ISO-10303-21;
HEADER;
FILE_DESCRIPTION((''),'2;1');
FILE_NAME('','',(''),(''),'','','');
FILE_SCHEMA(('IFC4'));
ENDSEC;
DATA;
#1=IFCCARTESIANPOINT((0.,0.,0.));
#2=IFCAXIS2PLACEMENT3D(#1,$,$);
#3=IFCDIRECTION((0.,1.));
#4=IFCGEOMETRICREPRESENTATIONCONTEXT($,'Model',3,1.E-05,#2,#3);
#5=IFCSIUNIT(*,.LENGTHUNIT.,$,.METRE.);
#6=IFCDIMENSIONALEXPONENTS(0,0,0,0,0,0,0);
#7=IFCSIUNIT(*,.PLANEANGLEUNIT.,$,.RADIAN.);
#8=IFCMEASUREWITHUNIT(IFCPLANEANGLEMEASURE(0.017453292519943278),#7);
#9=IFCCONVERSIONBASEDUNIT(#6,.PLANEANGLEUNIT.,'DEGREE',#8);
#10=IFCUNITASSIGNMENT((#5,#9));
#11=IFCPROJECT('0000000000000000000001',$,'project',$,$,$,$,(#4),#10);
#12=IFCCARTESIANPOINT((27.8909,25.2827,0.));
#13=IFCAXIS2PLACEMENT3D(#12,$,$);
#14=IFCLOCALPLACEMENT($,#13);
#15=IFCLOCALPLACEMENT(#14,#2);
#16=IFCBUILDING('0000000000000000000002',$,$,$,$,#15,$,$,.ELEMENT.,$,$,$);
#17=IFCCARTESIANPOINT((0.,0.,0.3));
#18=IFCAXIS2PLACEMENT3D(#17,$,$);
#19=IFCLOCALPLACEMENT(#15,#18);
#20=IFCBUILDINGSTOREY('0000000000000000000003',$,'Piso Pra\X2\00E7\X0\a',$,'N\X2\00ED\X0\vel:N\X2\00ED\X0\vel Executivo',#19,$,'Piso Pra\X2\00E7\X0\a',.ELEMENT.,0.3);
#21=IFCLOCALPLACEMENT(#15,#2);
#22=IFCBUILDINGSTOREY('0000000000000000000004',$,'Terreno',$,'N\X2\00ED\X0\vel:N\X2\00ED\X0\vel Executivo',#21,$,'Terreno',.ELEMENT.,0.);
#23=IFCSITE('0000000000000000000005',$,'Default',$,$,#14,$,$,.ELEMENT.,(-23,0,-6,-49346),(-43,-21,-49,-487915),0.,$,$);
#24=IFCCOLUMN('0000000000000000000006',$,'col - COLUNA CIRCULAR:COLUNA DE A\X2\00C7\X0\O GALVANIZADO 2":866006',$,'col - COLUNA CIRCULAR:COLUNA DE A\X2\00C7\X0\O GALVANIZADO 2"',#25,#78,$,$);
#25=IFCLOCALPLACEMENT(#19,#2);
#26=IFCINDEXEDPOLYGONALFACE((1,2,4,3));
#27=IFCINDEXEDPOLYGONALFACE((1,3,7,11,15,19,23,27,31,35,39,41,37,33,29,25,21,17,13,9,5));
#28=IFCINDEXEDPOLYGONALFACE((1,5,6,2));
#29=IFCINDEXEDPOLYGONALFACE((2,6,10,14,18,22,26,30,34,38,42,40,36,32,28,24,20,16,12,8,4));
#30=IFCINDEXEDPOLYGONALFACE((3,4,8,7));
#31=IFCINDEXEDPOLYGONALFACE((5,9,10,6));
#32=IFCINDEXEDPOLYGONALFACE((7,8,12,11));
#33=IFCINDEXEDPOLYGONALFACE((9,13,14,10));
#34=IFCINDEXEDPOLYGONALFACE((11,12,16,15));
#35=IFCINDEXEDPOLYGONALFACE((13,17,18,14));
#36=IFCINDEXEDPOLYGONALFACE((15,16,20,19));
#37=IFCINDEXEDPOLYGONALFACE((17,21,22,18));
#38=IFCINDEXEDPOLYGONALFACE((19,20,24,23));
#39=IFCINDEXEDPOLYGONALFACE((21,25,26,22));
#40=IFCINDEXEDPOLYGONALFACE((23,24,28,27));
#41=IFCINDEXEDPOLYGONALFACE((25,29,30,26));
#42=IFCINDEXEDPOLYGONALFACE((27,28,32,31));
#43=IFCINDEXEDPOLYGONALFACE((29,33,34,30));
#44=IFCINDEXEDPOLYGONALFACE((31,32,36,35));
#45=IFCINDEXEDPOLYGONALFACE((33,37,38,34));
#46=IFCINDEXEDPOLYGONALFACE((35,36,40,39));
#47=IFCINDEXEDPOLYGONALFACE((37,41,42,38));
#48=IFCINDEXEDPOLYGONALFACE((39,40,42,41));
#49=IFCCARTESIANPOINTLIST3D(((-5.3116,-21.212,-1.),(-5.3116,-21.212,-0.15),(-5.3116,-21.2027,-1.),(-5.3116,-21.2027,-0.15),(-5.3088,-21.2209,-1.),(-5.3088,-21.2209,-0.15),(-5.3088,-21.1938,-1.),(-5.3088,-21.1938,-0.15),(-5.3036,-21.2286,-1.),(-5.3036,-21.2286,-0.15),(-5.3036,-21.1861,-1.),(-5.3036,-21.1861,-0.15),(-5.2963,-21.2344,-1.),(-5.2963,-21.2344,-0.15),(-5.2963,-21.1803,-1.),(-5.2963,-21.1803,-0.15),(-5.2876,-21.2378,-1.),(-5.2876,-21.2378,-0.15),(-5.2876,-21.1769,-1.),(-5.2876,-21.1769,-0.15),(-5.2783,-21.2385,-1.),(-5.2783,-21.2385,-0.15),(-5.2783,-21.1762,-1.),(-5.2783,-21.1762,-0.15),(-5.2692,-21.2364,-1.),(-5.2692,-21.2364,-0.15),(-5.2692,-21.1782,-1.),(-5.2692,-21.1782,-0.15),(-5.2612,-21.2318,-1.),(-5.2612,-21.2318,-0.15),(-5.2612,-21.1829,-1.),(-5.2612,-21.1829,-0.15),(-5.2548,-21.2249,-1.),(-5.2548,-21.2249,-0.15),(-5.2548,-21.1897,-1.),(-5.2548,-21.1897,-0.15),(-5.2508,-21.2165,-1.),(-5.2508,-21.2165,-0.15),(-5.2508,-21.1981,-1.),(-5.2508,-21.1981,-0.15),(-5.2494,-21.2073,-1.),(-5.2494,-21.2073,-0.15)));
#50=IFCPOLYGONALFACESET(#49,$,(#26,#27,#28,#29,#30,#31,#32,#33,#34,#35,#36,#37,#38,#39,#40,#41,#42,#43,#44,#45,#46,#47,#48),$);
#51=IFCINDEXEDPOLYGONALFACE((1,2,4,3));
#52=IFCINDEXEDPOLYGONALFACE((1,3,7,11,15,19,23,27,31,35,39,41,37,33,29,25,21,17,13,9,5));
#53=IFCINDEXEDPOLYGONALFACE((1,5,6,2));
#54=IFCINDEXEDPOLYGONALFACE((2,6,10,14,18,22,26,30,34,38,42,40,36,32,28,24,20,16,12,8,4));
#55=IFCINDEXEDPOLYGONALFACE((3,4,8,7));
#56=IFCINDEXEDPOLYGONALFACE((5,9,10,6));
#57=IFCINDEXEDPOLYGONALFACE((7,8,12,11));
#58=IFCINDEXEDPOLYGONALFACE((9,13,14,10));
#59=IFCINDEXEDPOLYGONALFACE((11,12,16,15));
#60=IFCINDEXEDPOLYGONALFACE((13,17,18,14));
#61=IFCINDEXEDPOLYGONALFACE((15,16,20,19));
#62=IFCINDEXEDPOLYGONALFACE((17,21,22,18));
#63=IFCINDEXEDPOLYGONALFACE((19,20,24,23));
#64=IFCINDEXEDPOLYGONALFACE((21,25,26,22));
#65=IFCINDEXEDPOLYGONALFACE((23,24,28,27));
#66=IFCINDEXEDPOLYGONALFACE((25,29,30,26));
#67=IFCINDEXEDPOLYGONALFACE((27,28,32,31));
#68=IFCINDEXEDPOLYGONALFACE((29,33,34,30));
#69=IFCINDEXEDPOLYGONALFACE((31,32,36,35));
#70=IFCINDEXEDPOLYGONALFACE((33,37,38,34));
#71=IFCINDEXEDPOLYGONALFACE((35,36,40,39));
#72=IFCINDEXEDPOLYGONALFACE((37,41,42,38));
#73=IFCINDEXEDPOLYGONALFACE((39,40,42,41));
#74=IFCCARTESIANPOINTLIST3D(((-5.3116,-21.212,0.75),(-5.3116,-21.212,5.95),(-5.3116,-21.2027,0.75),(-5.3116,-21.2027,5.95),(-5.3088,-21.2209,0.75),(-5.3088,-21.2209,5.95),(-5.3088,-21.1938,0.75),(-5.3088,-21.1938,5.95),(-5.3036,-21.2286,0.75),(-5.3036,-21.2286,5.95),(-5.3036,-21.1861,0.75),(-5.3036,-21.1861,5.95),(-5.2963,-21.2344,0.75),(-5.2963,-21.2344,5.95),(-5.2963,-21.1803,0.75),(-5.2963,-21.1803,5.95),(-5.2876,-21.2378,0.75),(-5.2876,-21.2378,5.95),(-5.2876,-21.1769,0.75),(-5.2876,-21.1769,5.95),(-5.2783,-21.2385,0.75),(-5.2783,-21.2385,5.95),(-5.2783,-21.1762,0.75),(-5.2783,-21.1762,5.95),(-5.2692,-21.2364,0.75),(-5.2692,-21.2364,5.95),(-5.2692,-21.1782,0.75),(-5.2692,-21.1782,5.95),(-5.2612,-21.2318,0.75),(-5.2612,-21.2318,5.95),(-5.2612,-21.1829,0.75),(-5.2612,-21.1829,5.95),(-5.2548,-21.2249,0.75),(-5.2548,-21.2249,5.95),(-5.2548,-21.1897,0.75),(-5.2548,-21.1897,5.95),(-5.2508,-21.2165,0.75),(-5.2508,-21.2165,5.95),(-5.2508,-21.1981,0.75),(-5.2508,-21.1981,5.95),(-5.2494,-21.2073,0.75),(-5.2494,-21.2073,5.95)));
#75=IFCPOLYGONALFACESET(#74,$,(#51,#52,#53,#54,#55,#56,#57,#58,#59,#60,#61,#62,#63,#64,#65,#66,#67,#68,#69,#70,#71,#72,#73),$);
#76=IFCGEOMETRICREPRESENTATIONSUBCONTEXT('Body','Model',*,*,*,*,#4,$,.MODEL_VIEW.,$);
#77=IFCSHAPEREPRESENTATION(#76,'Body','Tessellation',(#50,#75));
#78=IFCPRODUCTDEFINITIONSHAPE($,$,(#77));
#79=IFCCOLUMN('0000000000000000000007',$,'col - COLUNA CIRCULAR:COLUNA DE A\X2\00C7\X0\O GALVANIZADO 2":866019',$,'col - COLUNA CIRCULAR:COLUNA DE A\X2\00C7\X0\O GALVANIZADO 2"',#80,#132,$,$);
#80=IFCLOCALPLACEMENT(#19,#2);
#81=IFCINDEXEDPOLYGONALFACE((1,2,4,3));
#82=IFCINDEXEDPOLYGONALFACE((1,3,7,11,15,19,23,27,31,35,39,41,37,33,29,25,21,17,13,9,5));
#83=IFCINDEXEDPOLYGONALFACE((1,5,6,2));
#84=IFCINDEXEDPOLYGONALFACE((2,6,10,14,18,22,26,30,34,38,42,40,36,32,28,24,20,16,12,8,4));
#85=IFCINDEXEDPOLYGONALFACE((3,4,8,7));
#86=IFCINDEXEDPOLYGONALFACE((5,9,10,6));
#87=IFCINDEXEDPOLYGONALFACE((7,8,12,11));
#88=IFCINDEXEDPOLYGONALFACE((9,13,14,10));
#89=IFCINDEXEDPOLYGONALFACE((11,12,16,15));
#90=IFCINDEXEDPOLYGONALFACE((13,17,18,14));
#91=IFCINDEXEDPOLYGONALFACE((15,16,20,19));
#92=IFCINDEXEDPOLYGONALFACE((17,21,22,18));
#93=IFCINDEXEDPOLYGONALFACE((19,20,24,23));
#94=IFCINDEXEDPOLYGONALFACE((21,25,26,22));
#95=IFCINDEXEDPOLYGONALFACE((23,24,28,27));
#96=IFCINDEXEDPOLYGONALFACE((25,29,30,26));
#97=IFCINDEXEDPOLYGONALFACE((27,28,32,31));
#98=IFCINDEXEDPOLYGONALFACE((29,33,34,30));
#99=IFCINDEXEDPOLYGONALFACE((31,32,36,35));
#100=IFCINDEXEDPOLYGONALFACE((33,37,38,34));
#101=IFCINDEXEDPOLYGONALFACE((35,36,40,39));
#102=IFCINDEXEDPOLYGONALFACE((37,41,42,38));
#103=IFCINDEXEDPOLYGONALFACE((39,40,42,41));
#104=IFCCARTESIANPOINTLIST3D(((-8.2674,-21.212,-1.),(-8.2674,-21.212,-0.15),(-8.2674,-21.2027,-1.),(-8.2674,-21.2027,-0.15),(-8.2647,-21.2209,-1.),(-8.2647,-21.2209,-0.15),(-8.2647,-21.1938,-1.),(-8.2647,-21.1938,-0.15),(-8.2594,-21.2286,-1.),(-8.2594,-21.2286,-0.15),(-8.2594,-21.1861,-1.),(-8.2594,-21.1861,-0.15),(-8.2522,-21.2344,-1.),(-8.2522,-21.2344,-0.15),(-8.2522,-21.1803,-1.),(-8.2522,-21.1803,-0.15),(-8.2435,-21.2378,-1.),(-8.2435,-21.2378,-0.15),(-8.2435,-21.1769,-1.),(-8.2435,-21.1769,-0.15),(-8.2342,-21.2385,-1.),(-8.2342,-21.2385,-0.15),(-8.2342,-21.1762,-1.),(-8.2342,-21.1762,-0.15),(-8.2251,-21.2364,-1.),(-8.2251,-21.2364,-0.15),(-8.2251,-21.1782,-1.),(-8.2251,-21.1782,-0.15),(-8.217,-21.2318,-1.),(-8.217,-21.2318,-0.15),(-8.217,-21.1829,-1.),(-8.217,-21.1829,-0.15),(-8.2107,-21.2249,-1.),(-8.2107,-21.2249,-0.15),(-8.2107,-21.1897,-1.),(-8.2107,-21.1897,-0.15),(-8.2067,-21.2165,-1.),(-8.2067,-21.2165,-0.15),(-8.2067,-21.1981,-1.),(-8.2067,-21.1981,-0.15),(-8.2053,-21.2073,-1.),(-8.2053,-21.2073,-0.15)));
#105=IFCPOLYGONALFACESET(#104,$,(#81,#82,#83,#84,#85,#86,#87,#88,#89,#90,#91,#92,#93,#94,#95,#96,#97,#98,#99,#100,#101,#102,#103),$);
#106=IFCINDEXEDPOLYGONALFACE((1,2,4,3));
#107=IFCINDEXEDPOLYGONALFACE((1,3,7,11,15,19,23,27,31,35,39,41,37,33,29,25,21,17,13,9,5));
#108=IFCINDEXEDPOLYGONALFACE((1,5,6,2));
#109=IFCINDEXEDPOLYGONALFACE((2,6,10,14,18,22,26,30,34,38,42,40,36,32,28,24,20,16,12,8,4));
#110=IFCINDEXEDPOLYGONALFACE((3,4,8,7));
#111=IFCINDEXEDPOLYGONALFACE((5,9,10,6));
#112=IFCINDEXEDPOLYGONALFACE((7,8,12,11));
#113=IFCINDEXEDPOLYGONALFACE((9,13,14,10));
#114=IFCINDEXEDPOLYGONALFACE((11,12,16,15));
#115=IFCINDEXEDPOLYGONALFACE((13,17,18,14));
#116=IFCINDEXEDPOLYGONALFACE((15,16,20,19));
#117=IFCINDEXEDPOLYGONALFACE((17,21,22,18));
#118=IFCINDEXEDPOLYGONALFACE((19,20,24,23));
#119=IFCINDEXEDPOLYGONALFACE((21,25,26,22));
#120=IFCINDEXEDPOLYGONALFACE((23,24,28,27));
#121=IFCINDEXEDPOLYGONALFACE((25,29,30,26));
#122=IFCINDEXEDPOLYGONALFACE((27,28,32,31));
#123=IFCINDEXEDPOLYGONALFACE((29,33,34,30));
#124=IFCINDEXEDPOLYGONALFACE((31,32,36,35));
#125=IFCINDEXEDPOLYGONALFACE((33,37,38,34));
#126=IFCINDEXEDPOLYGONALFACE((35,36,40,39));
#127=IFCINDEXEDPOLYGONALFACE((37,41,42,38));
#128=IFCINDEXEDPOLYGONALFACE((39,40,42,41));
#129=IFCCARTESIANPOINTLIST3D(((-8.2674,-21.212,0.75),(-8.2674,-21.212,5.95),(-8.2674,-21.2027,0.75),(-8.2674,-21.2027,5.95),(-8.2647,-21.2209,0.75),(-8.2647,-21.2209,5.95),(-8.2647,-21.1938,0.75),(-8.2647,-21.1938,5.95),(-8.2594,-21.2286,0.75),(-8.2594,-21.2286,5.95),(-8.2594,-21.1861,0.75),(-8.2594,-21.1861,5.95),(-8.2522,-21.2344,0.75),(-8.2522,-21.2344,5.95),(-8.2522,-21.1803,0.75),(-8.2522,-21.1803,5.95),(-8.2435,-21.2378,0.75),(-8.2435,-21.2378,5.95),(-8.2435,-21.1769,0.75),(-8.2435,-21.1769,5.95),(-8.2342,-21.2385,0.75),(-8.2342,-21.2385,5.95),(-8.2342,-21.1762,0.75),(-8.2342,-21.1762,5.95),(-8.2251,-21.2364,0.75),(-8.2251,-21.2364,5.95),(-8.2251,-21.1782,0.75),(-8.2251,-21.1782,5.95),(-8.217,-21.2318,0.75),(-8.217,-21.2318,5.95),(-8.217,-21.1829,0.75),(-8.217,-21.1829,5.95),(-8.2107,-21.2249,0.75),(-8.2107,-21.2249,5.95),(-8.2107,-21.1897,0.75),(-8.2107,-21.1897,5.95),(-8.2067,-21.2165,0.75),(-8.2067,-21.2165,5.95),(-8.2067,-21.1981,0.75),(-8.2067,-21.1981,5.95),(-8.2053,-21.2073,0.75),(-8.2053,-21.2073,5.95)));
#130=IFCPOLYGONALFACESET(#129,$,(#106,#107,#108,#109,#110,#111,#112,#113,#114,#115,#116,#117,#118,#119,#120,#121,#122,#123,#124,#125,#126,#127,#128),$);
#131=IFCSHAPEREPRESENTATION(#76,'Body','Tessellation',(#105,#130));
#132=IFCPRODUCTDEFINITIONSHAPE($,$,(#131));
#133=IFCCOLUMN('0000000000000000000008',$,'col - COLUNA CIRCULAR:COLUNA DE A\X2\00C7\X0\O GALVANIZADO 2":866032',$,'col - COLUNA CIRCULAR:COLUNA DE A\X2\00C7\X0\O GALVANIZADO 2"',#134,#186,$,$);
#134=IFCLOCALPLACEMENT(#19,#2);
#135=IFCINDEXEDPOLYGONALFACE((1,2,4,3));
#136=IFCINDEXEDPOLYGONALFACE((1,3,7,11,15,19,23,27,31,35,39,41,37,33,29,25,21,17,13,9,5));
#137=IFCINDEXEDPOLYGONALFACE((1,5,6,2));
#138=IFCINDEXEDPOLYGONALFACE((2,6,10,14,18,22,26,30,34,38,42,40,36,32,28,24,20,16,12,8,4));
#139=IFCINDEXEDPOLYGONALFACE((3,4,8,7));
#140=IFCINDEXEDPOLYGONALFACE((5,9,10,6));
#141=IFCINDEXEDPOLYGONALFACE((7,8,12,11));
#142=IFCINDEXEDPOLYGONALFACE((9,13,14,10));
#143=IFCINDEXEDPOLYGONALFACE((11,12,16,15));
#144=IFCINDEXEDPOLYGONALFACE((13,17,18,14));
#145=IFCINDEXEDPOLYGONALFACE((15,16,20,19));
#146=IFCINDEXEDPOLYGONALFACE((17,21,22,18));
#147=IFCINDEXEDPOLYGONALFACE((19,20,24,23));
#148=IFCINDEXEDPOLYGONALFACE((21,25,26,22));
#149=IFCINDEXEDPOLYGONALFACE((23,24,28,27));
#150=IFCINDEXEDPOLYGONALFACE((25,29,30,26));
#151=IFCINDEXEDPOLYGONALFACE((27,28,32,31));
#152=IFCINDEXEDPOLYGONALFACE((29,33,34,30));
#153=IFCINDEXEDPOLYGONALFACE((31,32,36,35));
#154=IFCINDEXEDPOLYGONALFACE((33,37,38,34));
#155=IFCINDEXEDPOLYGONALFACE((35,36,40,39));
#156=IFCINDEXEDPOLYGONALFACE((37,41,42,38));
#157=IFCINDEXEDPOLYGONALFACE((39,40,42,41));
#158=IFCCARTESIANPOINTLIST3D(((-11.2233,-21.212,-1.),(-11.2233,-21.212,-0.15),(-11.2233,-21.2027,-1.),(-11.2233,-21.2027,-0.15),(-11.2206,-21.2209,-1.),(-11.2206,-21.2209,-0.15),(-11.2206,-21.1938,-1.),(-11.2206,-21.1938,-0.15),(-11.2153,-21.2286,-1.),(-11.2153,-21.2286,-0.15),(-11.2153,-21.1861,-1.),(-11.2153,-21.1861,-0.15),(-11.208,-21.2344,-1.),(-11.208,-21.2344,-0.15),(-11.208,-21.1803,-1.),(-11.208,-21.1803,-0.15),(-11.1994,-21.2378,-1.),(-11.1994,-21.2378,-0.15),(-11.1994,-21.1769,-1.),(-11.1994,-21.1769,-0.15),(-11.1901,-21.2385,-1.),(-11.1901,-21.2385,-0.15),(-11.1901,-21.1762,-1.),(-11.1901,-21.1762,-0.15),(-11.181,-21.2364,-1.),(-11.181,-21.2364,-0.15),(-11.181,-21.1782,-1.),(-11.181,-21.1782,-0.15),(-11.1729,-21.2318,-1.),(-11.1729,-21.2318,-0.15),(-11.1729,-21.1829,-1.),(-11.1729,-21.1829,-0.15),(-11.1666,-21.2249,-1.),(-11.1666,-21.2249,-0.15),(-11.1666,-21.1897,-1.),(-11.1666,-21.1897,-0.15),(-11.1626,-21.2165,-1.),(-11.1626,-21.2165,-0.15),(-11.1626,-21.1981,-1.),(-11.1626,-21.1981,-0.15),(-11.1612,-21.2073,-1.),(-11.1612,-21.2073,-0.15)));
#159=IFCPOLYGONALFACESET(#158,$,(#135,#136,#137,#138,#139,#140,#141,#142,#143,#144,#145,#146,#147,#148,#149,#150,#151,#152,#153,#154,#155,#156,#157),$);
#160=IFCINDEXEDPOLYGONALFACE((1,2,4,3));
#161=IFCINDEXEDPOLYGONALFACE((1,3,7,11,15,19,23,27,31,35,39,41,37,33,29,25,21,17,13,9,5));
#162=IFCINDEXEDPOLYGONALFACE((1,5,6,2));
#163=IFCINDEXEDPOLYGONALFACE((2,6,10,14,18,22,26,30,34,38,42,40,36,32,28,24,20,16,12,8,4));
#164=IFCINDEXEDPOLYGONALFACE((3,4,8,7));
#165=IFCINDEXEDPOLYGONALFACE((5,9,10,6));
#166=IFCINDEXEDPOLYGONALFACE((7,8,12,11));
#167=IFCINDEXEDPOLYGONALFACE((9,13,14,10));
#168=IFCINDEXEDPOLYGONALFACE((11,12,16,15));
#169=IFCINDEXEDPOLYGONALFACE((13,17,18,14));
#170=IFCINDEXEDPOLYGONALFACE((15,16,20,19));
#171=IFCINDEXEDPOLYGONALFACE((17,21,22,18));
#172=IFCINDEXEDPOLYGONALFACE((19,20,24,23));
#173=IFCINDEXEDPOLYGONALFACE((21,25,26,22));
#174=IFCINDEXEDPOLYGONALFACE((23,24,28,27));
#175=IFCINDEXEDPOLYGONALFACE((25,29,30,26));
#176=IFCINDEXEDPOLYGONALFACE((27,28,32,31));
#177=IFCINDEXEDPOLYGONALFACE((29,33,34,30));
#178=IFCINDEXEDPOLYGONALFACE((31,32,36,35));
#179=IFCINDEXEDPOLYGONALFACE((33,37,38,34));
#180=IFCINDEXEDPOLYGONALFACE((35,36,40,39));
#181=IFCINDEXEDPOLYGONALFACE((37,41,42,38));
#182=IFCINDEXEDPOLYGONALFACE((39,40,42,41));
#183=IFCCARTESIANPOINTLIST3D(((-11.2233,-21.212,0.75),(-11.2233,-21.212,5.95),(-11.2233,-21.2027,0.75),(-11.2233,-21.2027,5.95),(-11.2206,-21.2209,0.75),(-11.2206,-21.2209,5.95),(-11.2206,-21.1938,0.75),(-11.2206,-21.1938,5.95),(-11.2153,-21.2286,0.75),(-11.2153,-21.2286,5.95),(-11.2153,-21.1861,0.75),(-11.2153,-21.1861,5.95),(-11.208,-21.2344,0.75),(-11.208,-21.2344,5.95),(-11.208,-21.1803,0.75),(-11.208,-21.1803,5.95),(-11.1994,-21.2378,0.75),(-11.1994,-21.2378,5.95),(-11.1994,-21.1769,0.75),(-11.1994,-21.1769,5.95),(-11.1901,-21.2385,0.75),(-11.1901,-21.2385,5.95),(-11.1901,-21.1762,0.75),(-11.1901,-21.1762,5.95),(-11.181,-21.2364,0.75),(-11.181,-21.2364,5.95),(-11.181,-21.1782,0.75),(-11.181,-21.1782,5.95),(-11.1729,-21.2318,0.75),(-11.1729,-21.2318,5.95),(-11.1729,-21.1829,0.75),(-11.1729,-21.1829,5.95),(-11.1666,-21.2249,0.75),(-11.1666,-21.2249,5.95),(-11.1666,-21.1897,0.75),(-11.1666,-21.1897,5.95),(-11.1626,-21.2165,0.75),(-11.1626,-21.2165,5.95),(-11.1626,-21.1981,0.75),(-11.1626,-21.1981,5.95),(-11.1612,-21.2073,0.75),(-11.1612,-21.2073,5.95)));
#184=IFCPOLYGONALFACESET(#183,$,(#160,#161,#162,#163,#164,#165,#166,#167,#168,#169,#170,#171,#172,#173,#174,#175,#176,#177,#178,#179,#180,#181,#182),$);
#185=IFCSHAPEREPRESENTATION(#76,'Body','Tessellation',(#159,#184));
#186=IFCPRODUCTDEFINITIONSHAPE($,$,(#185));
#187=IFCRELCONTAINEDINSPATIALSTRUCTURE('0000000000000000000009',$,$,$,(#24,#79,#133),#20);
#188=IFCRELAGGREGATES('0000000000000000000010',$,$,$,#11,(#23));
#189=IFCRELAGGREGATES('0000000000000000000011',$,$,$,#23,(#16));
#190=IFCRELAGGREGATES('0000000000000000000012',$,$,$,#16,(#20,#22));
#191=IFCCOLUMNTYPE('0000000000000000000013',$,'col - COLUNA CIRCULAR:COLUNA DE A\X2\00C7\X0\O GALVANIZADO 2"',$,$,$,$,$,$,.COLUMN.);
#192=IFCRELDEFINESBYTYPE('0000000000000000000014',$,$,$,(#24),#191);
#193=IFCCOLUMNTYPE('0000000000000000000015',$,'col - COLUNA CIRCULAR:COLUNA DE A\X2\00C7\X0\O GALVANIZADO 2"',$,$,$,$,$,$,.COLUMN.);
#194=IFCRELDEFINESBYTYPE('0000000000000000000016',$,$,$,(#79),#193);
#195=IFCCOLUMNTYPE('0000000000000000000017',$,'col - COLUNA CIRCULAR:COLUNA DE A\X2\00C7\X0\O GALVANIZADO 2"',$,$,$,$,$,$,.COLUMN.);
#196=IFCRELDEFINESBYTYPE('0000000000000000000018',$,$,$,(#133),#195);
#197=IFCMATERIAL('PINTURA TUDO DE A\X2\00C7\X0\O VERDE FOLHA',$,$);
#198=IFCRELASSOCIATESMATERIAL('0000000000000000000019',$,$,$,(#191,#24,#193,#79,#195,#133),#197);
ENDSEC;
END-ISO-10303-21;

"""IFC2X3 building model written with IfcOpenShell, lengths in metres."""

from ifc_helpers import new_model, entity, si_unit, converted_unit, direction, frame, origin, origin_2d_with_axis, place, context, subcontext, project, spatial, circle, extrude, source, transform, mapped, material, type_object, type_shapes, element, save


model = new_model("IFC2X3")

# Units and contexts
model_context = context("Model", 3, precision=1e-05, world=origin(), true_north=direction((0.0, 1.0)))
body_context = subcontext(model_context, "Body", "Model", "MODEL_VIEW")
ifc_project = project(units=[si_unit("LENGTHUNIT", "METRE"), converted_unit("PLANEANGLEUNIT", "DEGREE", entity("IfcPlaneAngleMeasure", 0.017453292519943278), si_unit("PLANEANGLEUNIT", "RADIAN"), dimensions=[0, 0, 0, 0, 0, 0, 0])], contexts=[model_context])

# Site, building, storey
site_placement = place(None, frame((27.8909, 25.2827, 0.0)))
site = spatial("IfcSite", under=ifc_project, at=site_placement, Name="Default", CompositionType="ELEMENT", RefLatitude=(-23, 0, -6, -49346), RefLongitude=(-43, -21, -49, -487915), RefElevation=0.0)
building_placement = place(site_placement, origin())
building = spatial("IfcBuilding", under=site, at=building_placement, CompositionType="ELEMENT")
storey_1_placement = place(building_placement, frame((0.0, 0.0, 0.3)))
storey_1 = spatial("IfcBuildingStorey", under=building, at=storey_1_placement, Name="Piso Praça", ObjectType="Nível:Nível Executivo", LongName="Piso Praça", CompositionType="ELEMENT", Elevation=0.3)

# Columns
ifc_material_1 = material(Name="PINTURA TUDO DE AÇO VERDE FOLHA")
column_type_1 = type_object("IfcColumnType", Name="col - COLUNA CIRCULAR:COLUNA DE AÇO GALVANIZADO 2\"", PredefinedType="COLUMN", material=ifc_material_1)
shared_shape_1 = source(origin(), body_context, "Body", "SweptSolid", [
    extrude(circle(Radius=0.0312, at=origin_2d_with_axis()), frame((-5.2807, -21.2073, -0.7)), (0.0, 0.0, 1.0), 0.85),
    extrude(circle(Radius=0.0312, at=origin_2d_with_axis()), frame((-5.2807, -21.2073, 1.05)), (0.0, 0.0, 1.0), 5.2),
])
type_shapes(column_type_1, [shared_shape_1])
column_1_placement = place(storey_1_placement, frame((0.0, 0.0, -0.3)))
element("IfcColumn", 1, at=column_1_placement, inside=storey_1, type_object=column_type_1, material=ifc_material_1, Name="col - COLUNA CIRCULAR:COLUNA DE AÇO GALVANIZADO 2\":866006", ObjectType="col - COLUNA CIRCULAR:COLUNA DE AÇO GALVANIZADO 2\"", context=body_context, shape_type="MappedRepresentation", body=[
    mapped(shared_shape_1, transform((0.0, 0.0, 0.0), scale=1.0)),
])
column_type_2 = type_object("IfcColumnType", Name="col - COLUNA CIRCULAR:COLUNA DE AÇO GALVANIZADO 2\"", PredefinedType="COLUMN", material=ifc_material_1)
shared_shape_2 = source(origin(), body_context, "Body", "SweptSolid", [
    extrude(circle(Radius=0.0312, at=origin_2d_with_axis()), frame((-8.2365, -21.2073, -0.7)), (0.0, 0.0, 1.0), 0.85),
    extrude(circle(Radius=0.0312, at=origin_2d_with_axis()), frame((-8.2365, -21.2073, 1.05)), (0.0, 0.0, 1.0), 5.2),
])
type_shapes(column_type_2, [shared_shape_2])
column_2_placement = place(storey_1_placement, frame((0.0, 0.0, -0.3)))
element("IfcColumn", 2, at=column_2_placement, inside=storey_1, type_object=column_type_2, material=ifc_material_1, Name="col - COLUNA CIRCULAR:COLUNA DE AÇO GALVANIZADO 2\":866019", ObjectType="col - COLUNA CIRCULAR:COLUNA DE AÇO GALVANIZADO 2\"", context=body_context, shape_type="MappedRepresentation", body=[
    mapped(shared_shape_2, transform((0.0, 0.0, 0.0), scale=1.0)),
])
column_type_3 = type_object("IfcColumnType", Name="col - COLUNA CIRCULAR:COLUNA DE AÇO GALVANIZADO 2\"", PredefinedType="COLUMN", material=ifc_material_1)
shared_shape_3 = source(origin(), body_context, "Body", "SweptSolid", [
    extrude(circle(Radius=0.0312, at=origin_2d_with_axis()), frame((-11.1924, -21.2073, -0.7)), (0.0, 0.0, 1.0), 0.85),
    extrude(circle(Radius=0.0312, at=origin_2d_with_axis()), frame((-11.1924, -21.2073, 1.05)), (0.0, 0.0, 1.0), 5.2),
])
type_shapes(column_type_3, [shared_shape_3])
column_3_placement = place(storey_1_placement, frame((0.0, 0.0, -0.3)))
element("IfcColumn", 3, at=column_3_placement, inside=storey_1, type_object=column_type_3, material=ifc_material_1, Name="col - COLUNA CIRCULAR:COLUNA DE AÇO GALVANIZADO 2\":866032", ObjectType="col - COLUNA CIRCULAR:COLUNA DE AÇO GALVANIZADO 2\"", context=body_context, shape_type="MappedRepresentation", body=[
    mapped(shared_shape_3, transform((0.0, 0.0, 0.0), scale=1.0)),
])

# Shared definitions
storey_2_placement = place(building_placement, origin())
storey_2 = spatial("IfcBuildingStorey", under=building, at=storey_2_placement, Name="Terreno", ObjectType="Nível:Nível Executivo", LongName="Terreno", CompositionType="ELEMENT", Elevation=0.0)

save(model, "model.ifc")
